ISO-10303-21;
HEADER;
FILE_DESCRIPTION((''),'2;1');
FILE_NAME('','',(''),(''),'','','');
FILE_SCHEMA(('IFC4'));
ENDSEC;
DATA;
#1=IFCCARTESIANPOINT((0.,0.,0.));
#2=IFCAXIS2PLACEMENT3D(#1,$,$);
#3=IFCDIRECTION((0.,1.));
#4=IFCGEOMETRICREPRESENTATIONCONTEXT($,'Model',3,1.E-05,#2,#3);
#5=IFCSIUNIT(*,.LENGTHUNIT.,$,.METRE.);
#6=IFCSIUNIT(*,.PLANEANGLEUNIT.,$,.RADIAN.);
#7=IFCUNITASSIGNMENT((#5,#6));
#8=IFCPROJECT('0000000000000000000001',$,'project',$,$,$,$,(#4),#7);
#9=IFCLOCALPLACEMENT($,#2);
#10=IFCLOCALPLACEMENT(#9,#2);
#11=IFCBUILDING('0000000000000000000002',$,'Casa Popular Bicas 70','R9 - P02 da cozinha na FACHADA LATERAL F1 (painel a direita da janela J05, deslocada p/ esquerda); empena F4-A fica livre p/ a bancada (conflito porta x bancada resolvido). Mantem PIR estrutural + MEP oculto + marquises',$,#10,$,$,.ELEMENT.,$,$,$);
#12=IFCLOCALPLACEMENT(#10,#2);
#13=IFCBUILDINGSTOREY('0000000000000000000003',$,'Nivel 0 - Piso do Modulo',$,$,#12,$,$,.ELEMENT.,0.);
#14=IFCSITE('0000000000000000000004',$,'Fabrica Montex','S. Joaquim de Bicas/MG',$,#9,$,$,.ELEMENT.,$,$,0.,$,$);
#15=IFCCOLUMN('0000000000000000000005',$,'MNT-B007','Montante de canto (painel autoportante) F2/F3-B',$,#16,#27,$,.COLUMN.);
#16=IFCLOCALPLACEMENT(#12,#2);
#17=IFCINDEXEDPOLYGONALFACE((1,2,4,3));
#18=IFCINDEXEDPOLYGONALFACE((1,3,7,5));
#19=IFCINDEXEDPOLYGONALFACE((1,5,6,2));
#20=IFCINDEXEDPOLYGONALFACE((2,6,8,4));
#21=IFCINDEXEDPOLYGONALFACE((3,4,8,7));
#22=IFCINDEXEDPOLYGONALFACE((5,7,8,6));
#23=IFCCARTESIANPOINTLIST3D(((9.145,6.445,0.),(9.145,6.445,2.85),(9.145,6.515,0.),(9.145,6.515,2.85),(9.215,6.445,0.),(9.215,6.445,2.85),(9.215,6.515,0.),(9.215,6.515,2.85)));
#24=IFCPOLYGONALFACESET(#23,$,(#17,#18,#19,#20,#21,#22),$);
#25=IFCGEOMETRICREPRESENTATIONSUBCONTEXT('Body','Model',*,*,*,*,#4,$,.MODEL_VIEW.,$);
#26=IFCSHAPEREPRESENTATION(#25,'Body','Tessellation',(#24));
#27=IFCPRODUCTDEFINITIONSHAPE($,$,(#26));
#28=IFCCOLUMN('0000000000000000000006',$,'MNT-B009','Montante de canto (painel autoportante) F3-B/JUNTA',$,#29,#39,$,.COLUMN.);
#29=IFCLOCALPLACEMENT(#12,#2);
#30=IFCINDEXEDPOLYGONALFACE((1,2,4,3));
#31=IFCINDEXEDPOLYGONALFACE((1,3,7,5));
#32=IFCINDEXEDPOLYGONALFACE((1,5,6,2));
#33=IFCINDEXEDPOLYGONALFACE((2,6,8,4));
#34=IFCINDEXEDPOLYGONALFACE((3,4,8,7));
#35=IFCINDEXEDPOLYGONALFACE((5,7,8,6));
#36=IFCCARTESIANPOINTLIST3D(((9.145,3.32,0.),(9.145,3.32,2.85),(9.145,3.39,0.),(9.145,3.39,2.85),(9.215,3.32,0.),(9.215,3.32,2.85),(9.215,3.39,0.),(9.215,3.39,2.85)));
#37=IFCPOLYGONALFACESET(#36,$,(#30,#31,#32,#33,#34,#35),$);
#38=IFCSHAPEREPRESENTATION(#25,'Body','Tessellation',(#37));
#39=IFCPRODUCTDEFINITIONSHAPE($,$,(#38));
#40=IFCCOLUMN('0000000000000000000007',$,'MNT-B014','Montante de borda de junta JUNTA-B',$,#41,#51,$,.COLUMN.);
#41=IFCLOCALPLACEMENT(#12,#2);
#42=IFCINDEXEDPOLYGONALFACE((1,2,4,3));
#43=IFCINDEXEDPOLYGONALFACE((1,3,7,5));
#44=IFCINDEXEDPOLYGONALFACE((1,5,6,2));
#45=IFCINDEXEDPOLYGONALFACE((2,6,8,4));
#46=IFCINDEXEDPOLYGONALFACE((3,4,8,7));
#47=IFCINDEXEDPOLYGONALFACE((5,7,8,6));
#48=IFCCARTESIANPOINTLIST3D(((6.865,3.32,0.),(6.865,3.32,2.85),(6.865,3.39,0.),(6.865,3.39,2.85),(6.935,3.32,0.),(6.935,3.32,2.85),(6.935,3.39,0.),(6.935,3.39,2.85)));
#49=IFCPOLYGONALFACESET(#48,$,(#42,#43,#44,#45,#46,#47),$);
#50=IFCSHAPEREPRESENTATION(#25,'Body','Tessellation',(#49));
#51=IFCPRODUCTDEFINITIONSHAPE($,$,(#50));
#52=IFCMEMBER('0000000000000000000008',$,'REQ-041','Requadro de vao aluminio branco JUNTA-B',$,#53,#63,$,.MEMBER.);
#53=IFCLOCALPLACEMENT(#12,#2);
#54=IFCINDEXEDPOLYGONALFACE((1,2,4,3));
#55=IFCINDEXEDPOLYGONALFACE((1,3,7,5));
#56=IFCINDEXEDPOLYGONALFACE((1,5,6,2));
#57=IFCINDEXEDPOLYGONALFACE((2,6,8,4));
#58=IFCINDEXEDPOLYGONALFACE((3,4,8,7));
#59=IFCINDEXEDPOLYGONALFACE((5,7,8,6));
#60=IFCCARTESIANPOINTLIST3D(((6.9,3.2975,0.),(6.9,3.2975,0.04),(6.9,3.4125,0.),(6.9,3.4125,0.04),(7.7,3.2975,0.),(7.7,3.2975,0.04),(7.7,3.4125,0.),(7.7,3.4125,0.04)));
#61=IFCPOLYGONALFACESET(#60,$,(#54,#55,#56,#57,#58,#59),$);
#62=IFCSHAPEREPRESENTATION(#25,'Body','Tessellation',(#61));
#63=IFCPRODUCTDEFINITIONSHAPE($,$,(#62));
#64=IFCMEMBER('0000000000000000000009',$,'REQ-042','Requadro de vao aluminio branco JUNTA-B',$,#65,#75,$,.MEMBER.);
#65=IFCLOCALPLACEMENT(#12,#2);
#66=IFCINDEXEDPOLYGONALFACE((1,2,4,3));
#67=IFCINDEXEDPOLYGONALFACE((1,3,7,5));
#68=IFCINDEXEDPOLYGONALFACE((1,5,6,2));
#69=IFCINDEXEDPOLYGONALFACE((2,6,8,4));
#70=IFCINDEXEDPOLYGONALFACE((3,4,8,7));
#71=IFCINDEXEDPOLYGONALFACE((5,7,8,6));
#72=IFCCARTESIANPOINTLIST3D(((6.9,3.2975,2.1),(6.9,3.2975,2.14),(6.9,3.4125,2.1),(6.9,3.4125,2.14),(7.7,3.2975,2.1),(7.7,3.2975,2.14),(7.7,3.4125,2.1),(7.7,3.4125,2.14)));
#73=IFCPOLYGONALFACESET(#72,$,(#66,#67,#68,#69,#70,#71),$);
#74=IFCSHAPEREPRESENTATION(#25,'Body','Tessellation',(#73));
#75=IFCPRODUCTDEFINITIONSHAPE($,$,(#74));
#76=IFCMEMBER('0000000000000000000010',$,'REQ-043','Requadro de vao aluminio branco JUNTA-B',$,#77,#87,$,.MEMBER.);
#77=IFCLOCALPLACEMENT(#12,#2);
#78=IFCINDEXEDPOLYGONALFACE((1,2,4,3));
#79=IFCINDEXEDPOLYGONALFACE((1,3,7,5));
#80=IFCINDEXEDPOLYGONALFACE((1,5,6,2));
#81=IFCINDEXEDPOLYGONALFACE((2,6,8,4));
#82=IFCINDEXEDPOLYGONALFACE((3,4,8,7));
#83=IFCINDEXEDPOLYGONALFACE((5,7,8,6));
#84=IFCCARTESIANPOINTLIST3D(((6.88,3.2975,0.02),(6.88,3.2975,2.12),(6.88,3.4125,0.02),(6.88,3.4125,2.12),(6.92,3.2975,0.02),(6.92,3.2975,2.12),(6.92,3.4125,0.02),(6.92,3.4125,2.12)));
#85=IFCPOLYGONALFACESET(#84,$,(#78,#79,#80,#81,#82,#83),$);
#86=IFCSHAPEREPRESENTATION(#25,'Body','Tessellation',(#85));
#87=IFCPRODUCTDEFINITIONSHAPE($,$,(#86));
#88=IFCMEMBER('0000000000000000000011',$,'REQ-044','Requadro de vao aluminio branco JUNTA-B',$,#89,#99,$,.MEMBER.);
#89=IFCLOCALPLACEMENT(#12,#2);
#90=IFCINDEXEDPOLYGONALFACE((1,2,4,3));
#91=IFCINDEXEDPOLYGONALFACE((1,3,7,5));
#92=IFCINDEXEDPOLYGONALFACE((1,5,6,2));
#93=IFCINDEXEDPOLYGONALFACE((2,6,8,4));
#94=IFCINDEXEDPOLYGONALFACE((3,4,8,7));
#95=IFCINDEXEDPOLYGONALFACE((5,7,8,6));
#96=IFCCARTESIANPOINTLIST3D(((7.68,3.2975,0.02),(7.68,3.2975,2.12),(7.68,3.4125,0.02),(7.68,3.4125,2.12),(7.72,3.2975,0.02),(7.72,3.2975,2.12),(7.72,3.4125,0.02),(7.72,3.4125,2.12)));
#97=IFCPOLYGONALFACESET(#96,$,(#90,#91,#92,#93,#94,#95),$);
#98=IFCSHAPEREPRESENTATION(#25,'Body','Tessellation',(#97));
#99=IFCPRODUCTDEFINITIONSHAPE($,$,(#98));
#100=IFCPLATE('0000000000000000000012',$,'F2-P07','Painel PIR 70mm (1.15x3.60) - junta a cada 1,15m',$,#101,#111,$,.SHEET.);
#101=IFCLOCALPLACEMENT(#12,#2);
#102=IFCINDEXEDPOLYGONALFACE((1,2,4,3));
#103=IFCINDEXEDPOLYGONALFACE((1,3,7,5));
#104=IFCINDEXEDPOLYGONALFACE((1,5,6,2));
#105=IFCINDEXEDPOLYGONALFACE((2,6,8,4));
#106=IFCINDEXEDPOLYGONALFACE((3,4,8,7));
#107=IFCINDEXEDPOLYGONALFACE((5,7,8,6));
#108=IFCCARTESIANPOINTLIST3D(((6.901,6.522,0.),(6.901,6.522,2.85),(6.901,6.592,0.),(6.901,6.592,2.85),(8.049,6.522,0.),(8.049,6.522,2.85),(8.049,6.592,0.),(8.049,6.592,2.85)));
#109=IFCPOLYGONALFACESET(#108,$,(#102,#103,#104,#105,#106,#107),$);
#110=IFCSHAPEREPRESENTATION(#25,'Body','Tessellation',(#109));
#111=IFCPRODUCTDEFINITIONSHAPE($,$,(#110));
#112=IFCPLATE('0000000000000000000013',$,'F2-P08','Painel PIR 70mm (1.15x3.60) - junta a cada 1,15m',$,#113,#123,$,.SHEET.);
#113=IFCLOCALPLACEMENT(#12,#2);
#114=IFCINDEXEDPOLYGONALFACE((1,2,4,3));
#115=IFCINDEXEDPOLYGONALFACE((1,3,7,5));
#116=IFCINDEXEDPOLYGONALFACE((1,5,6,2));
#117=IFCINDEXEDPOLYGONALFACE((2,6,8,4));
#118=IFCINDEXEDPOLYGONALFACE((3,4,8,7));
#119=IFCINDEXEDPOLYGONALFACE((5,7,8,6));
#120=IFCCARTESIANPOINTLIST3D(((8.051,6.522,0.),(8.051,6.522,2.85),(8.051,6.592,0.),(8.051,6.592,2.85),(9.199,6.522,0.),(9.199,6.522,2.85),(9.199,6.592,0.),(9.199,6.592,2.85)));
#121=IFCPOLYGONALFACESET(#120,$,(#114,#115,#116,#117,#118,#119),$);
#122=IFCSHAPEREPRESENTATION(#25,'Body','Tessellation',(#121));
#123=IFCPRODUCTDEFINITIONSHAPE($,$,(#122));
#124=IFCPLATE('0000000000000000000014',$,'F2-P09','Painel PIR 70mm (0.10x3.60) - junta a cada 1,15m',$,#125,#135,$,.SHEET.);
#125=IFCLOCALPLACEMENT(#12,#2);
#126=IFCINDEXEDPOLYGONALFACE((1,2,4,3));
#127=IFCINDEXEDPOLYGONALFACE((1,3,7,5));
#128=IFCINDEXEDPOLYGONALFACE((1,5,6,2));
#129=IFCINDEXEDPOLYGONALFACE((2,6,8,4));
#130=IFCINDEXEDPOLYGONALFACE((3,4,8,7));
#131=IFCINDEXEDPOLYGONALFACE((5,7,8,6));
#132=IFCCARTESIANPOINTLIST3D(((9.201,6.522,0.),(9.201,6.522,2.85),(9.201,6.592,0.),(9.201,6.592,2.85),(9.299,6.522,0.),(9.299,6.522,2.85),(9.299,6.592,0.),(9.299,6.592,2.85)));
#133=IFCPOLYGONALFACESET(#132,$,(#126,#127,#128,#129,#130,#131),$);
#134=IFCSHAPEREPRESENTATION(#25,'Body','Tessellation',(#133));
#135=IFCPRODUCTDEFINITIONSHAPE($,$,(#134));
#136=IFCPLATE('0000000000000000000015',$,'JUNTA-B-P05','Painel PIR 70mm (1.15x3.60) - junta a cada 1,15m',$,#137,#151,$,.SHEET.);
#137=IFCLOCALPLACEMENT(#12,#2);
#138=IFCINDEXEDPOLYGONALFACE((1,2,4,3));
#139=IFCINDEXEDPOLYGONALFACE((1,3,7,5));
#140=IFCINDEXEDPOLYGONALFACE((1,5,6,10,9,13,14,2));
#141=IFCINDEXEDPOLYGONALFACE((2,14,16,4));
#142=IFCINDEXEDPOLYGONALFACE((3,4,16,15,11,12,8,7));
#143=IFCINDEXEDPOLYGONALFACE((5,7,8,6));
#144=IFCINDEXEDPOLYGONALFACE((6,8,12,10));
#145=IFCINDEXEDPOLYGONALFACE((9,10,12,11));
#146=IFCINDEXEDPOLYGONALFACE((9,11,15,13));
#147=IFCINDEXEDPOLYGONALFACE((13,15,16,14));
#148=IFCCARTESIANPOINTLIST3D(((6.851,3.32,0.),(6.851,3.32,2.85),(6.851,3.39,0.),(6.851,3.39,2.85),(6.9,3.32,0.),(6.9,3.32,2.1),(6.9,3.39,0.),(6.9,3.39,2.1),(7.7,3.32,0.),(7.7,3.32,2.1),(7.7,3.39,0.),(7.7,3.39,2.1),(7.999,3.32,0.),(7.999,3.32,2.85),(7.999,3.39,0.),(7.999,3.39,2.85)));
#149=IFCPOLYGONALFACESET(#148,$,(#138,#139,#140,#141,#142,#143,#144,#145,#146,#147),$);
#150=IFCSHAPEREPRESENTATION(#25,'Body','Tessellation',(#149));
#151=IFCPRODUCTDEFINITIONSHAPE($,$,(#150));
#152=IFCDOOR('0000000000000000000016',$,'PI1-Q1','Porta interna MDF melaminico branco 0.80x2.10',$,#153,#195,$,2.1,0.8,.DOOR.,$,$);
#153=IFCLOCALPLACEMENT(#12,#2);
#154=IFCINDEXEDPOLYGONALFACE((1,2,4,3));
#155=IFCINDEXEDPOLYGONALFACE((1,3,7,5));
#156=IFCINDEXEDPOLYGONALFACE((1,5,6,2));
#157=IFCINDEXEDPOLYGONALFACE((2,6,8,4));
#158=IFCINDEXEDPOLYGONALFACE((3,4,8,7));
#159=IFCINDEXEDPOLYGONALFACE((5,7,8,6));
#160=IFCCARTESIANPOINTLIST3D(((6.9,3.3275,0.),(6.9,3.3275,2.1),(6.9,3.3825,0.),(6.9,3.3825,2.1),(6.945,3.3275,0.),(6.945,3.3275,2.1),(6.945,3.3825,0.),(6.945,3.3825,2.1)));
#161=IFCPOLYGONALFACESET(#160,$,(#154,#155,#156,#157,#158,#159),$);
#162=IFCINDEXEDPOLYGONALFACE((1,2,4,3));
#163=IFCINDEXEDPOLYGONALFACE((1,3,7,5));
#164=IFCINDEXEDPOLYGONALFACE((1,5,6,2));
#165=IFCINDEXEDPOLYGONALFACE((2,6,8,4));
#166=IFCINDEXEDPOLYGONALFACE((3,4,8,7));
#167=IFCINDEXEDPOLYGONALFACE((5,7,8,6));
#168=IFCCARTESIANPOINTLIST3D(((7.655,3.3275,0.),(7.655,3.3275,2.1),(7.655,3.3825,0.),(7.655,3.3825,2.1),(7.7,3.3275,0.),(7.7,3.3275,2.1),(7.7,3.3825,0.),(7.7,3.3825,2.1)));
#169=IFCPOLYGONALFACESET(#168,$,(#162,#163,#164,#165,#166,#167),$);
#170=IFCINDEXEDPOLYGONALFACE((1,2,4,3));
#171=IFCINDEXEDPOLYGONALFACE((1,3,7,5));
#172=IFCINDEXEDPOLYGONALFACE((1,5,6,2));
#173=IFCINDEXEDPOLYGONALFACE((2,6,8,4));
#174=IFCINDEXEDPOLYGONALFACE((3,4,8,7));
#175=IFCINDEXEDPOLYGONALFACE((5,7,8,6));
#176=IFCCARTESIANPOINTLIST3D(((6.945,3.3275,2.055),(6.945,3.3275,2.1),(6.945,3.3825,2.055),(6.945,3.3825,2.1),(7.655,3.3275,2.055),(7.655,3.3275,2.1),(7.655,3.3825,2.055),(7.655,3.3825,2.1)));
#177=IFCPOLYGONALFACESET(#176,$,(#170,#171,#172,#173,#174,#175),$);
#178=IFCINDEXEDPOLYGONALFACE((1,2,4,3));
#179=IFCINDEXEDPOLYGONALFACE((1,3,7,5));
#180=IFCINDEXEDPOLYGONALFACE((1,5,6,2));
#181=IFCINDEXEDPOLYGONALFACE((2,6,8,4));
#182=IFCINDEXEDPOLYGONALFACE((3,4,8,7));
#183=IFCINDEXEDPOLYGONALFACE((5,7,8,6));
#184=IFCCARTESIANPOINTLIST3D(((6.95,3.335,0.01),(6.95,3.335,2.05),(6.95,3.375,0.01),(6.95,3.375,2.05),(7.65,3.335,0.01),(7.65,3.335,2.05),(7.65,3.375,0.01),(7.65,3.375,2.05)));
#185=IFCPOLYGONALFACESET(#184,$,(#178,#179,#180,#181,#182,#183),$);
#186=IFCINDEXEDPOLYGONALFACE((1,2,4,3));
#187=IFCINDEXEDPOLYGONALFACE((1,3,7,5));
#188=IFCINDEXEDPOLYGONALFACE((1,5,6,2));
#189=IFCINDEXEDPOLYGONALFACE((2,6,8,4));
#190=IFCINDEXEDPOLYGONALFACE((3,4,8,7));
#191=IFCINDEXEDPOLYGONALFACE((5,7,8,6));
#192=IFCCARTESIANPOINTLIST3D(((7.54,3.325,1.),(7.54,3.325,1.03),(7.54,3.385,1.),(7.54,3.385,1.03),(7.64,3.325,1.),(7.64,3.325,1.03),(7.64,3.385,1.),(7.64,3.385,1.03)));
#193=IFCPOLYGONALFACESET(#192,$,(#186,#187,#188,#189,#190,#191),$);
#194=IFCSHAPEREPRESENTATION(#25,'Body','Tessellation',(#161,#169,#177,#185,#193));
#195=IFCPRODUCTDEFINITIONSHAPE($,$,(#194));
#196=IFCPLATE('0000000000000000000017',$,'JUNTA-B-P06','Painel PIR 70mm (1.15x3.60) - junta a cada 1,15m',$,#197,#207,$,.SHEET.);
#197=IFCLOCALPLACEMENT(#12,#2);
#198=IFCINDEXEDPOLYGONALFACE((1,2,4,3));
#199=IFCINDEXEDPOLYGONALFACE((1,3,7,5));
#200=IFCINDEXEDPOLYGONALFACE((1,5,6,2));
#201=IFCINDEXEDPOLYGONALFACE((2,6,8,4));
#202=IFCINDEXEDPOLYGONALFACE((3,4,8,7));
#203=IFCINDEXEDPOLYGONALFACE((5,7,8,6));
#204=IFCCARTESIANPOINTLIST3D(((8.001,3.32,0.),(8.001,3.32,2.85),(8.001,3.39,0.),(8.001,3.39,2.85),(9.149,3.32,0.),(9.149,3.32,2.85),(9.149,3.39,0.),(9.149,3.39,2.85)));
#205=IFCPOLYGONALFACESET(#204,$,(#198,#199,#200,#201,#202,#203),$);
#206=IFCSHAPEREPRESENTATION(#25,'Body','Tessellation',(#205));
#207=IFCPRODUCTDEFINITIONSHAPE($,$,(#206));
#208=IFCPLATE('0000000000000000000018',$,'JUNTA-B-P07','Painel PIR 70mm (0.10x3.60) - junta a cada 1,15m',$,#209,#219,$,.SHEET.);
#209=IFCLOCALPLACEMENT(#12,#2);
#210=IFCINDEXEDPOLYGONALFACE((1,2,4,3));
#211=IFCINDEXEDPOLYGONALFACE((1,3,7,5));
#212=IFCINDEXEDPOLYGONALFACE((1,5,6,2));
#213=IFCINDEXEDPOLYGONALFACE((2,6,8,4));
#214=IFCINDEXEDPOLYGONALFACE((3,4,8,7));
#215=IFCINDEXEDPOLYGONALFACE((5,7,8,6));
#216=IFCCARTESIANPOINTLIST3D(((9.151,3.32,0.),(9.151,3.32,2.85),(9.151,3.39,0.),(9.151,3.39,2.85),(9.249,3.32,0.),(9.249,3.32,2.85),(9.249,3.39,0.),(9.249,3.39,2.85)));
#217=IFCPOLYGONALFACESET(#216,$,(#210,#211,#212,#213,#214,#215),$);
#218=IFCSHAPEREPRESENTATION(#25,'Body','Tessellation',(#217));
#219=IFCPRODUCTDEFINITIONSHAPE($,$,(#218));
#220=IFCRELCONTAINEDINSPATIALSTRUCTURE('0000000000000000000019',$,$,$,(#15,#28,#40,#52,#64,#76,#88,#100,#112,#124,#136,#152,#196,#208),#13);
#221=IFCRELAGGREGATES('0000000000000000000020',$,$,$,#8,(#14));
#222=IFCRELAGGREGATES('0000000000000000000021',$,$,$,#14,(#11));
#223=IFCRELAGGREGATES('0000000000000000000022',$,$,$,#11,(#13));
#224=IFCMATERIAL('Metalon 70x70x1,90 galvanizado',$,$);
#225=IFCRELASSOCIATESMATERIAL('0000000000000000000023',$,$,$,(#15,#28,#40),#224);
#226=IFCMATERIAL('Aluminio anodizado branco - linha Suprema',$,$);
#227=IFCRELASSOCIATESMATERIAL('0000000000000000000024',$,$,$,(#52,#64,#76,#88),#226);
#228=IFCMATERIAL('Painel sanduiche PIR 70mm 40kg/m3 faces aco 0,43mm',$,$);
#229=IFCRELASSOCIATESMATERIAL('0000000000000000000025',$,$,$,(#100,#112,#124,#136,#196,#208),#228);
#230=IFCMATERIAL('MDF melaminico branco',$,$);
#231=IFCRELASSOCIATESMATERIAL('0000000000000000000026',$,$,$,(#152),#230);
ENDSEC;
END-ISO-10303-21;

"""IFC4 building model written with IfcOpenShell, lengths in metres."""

from ifc_helpers import new_model, si_unit, direction, frame, frame_2d, origin, origin_2d, place, context, subcontext, project, spatial, rectangle, extrude, material, element, fill, save


model = new_model("IFC4")

# Units and contexts
model_context = context("Model", 3, precision=1e-05, world=origin(), true_north=direction((0.0, 1.0)))
body_context = subcontext(model_context, "Body", "Model", "MODEL_VIEW")
ifc_project = project(units=[si_unit("LENGTHUNIT", "METRE"), si_unit("PLANEANGLEUNIT", "RADIAN")], contexts=[model_context])

# Site, building, storey
site_placement = place(None, origin())
site = spatial("IfcSite", under=ifc_project, at=site_placement, Name="Fabrica Montex", Description="S. Joaquim de Bicas/MG", CompositionType="ELEMENT", RefElevation=0.0)
building_placement = place(site_placement, origin())
building = spatial("IfcBuilding", under=site, at=building_placement, Name="Casa Popular Bicas 70", Description="R9 - P02 da cozinha na FACHADA LATERAL F1 (painel a direita da janela J05, deslocada p/ esquerda); empena F4-A fica livre p/ a bancada (conflito porta x bancada resolvido). Mantem PIR estrutural + MEP oculto + marquises", CompositionType="ELEMENT")
storey_placement = place(building_placement, origin())
storey = spatial("IfcBuildingStorey", under=building, at=storey_placement, Name="Nivel 0 - Piso do Modulo", CompositionType="ELEMENT", Elevation=0.0)

# Columns
ifc_material_1 = material(Name="Metalon 70x70x1,90 galvanizado")
for number, where, name, description in (
    (1, (9.18, 6.48, 0.0), "MNT-B007", "Montante de canto (painel autoportante) F2/F3-B"),
    (2, (9.18, 3.355, 0.0), "MNT-B009", "Montante de canto (painel autoportante) F3-B/JUNTA"),
    (3, (6.9, 3.355, 0.0), "MNT-B014", "Montante de borda de junta JUNTA-B"),
):
    element("IfcColumn", number, at=place(storey_placement, frame(where)), inside=storey, material=ifc_material_1, Name=name, Description=description, PredefinedType="COLUMN", context=body_context, shape_type="SweptSolid", body=[
        extrude(rectangle(XDim=0.07, YDim=0.07, at=origin_2d()), origin(), (0.0, 0.0, 1.0), 2.85),
    ])

# Members
ifc_material_2 = material(Name="Aluminio anodizado branco - linha Suprema")
for number, where, z_axis, x_axis, name in (
    (4, (6.9, 3.355, 0.02), (1.0, 0.0, 0.0), (0.0, 0.0, 1.0), "REQ-041"),
    (5, (6.9, 3.355, 2.12), (1.0, 0.0, 0.0), (0.0, 0.0, 1.0), "REQ-042"),
):
    element("IfcMember", number, at=place(storey_placement, frame(where, z_axis=z_axis, x_axis=x_axis)), inside=storey, material=ifc_material_2, Name=name, Description="Requadro de vao aluminio branco JUNTA-B", PredefinedType="MEMBER", context=body_context, shape_type="SweptSolid", body=[
        extrude(rectangle(XDim=0.04, YDim=0.115, at=origin_2d()), origin(), (0.0, 0.0, 1.0), 0.8),
    ])
for number, where, z_axis, x_axis, name in (
    (6, (6.9, 3.355, 0.02), (0.0, 0.0, 1.0), (1.0, 0.0, 0.0), "REQ-043"),
    (7, (7.7, 3.355, 0.02), (0.0, 0.0, 1.0), (1.0, 0.0, 0.0), "REQ-044"),
):
    element("IfcMember", number, at=place(storey_placement, frame(where, z_axis=z_axis, x_axis=x_axis)), inside=storey, material=ifc_material_2, Name=name, Description="Requadro de vao aluminio branco JUNTA-B", PredefinedType="MEMBER", context=body_context, shape_type="SweptSolid", body=[
        extrude(rectangle(XDim=0.04, YDim=0.115, at=origin_2d()), origin(), (0.0, 0.0, 1.0), 2.1),
    ])

# Plates
ifc_material_3 = material(Name="Painel sanduiche PIR 70mm 40kg/m3 faces aco 0,43mm")
for number, where, x_axis, name in (
    (8, (6.901, 6.557, 0.0), (1.0, 0.0, 0.0), "F2-P07"),
    (9, (8.051, 6.557, 0.0), (1.0, 0.0, 0.0), "F2-P08"),
):
    element("IfcPlate", number, at=place(storey_placement, frame(where, x_axis=x_axis)), inside=storey, material=ifc_material_3, Name=name, Description="Painel PIR 70mm (1.15x3.60) - junta a cada 1,15m", PredefinedType="SHEET", context=body_context, shape_type="SweptSolid", body=[
        extrude(rectangle(XDim=1.148, YDim=0.07, at=frame_2d((0.574, 0.0))), origin(), (0.0, 0.0, 1.0), 2.85),
    ])
plate_1_placement = place(storey_placement, frame((9.201, 6.557, 0.0), x_axis=(1.0, 0.0, 0.0)))
element("IfcPlate", 10, at=plate_1_placement, inside=storey, material=ifc_material_3, Name="F2-P09", Description="Painel PIR 70mm (0.10x3.60) - junta a cada 1,15m", PredefinedType="SHEET", context=body_context, shape_type="SweptSolid", body=[
    extrude(rectangle(XDim=0.098, YDim=0.07, at=frame_2d((0.049, 0.0))), origin(), (0.0, 0.0, 1.0), 2.85),
])

# Plate, opening, door
plate_2_placement = place(storey_placement, frame((6.851, 3.355, 0.0), x_axis=(1.0, 0.0, 0.0)))
plate_2 = element("IfcPlate", 11, at=plate_2_placement, inside=storey, material=ifc_material_3, Name="JUNTA-B-P05", Description="Painel PIR 70mm (1.15x3.60) - junta a cada 1,15m", PredefinedType="SHEET", context=body_context, shape_type="SweptSolid", body=[
    extrude(rectangle(XDim=1.148, YDim=0.07, at=frame_2d((0.574, 0.0))), origin(), (0.0, 0.0, 1.0), 2.85),
])
opening_1_placement = place(storey_placement, frame((7.3, 3.355, 0.0)))
opening_1 = element("IfcOpeningElement", 12, at=opening_1_placement, cuts=plate_2, PredefinedType="OPENING", context=body_context, shape_type="SweptSolid", body=[
    extrude(rectangle(XDim=0.8, YDim=0.1, at=origin_2d()), origin(), (0.0, 0.0, 1.0), 2.1),
])
ifc_material_4 = material(Name="MDF melaminico branco")
door_placement = place(storey_placement, frame((6.9, 3.355, 0.0), x_axis=(1.0, 0.0, 0.0)))
door = element("IfcDoor", 13, at=door_placement, inside=storey, material=ifc_material_4, Name="PI1-Q1", Description="Porta interna MDF melaminico branco 0.80x2.10", OverallHeight=2.1, OverallWidth=0.8, PredefinedType="DOOR", context=body_context, shape_type="SweptSolid", body=[
    extrude(rectangle(XDim=0.045, YDim=0.055, at=frame_2d((0.0225, 0.0))), origin(), (0.0, 0.0, 1.0), 2.1),
    extrude(rectangle(XDim=0.045, YDim=0.055, at=frame_2d((0.7775, 0.0))), origin(), (0.0, 0.0, 1.0), 2.1),
    extrude(rectangle(XDim=0.71, YDim=0.055, at=frame_2d((0.4, 0.0))), frame((0.0, 0.0, 2.055)), (0.0, 0.0, 1.0), 0.045),
    extrude(rectangle(XDim=0.7, YDim=0.04, at=frame_2d((0.4, 0.0))), frame((0.0, 0.0, 0.01)), (0.0, 0.0, 1.0), 2.04),
    extrude(rectangle(XDim=0.1, YDim=0.06, at=frame_2d((0.69, 0.0))), frame((0.0, 0.0, 1.0)), (0.0, 0.0, 1.0), 0.03),
])
fill(opening_1, door)

# Plates
plate_3_placement = place(storey_placement, frame((8.001, 3.355, 0.0), x_axis=(1.0, 0.0, 0.0)))
element("IfcPlate", 14, at=plate_3_placement, inside=storey, material=ifc_material_3, Name="JUNTA-B-P06", Description="Painel PIR 70mm (1.15x3.60) - junta a cada 1,15m", PredefinedType="SHEET", context=body_context, shape_type="SweptSolid", body=[
    extrude(rectangle(XDim=1.148, YDim=0.07, at=frame_2d((0.574, 0.0))), origin(), (0.0, 0.0, 1.0), 2.85),
])
plate_4_placement = place(storey_placement, frame((9.151, 3.355, 0.0), x_axis=(1.0, 0.0, 0.0)))
element("IfcPlate", 15, at=plate_4_placement, inside=storey, material=ifc_material_3, Name="JUNTA-B-P07", Description="Painel PIR 70mm (0.10x3.60) - junta a cada 1,15m", PredefinedType="SHEET", context=body_context, shape_type="SweptSolid", body=[
    extrude(rectangle(XDim=0.098, YDim=0.07, at=frame_2d((0.049, 0.0))), origin(), (0.0, 0.0, 1.0), 2.85),
])

save(model, "model.ifc")
